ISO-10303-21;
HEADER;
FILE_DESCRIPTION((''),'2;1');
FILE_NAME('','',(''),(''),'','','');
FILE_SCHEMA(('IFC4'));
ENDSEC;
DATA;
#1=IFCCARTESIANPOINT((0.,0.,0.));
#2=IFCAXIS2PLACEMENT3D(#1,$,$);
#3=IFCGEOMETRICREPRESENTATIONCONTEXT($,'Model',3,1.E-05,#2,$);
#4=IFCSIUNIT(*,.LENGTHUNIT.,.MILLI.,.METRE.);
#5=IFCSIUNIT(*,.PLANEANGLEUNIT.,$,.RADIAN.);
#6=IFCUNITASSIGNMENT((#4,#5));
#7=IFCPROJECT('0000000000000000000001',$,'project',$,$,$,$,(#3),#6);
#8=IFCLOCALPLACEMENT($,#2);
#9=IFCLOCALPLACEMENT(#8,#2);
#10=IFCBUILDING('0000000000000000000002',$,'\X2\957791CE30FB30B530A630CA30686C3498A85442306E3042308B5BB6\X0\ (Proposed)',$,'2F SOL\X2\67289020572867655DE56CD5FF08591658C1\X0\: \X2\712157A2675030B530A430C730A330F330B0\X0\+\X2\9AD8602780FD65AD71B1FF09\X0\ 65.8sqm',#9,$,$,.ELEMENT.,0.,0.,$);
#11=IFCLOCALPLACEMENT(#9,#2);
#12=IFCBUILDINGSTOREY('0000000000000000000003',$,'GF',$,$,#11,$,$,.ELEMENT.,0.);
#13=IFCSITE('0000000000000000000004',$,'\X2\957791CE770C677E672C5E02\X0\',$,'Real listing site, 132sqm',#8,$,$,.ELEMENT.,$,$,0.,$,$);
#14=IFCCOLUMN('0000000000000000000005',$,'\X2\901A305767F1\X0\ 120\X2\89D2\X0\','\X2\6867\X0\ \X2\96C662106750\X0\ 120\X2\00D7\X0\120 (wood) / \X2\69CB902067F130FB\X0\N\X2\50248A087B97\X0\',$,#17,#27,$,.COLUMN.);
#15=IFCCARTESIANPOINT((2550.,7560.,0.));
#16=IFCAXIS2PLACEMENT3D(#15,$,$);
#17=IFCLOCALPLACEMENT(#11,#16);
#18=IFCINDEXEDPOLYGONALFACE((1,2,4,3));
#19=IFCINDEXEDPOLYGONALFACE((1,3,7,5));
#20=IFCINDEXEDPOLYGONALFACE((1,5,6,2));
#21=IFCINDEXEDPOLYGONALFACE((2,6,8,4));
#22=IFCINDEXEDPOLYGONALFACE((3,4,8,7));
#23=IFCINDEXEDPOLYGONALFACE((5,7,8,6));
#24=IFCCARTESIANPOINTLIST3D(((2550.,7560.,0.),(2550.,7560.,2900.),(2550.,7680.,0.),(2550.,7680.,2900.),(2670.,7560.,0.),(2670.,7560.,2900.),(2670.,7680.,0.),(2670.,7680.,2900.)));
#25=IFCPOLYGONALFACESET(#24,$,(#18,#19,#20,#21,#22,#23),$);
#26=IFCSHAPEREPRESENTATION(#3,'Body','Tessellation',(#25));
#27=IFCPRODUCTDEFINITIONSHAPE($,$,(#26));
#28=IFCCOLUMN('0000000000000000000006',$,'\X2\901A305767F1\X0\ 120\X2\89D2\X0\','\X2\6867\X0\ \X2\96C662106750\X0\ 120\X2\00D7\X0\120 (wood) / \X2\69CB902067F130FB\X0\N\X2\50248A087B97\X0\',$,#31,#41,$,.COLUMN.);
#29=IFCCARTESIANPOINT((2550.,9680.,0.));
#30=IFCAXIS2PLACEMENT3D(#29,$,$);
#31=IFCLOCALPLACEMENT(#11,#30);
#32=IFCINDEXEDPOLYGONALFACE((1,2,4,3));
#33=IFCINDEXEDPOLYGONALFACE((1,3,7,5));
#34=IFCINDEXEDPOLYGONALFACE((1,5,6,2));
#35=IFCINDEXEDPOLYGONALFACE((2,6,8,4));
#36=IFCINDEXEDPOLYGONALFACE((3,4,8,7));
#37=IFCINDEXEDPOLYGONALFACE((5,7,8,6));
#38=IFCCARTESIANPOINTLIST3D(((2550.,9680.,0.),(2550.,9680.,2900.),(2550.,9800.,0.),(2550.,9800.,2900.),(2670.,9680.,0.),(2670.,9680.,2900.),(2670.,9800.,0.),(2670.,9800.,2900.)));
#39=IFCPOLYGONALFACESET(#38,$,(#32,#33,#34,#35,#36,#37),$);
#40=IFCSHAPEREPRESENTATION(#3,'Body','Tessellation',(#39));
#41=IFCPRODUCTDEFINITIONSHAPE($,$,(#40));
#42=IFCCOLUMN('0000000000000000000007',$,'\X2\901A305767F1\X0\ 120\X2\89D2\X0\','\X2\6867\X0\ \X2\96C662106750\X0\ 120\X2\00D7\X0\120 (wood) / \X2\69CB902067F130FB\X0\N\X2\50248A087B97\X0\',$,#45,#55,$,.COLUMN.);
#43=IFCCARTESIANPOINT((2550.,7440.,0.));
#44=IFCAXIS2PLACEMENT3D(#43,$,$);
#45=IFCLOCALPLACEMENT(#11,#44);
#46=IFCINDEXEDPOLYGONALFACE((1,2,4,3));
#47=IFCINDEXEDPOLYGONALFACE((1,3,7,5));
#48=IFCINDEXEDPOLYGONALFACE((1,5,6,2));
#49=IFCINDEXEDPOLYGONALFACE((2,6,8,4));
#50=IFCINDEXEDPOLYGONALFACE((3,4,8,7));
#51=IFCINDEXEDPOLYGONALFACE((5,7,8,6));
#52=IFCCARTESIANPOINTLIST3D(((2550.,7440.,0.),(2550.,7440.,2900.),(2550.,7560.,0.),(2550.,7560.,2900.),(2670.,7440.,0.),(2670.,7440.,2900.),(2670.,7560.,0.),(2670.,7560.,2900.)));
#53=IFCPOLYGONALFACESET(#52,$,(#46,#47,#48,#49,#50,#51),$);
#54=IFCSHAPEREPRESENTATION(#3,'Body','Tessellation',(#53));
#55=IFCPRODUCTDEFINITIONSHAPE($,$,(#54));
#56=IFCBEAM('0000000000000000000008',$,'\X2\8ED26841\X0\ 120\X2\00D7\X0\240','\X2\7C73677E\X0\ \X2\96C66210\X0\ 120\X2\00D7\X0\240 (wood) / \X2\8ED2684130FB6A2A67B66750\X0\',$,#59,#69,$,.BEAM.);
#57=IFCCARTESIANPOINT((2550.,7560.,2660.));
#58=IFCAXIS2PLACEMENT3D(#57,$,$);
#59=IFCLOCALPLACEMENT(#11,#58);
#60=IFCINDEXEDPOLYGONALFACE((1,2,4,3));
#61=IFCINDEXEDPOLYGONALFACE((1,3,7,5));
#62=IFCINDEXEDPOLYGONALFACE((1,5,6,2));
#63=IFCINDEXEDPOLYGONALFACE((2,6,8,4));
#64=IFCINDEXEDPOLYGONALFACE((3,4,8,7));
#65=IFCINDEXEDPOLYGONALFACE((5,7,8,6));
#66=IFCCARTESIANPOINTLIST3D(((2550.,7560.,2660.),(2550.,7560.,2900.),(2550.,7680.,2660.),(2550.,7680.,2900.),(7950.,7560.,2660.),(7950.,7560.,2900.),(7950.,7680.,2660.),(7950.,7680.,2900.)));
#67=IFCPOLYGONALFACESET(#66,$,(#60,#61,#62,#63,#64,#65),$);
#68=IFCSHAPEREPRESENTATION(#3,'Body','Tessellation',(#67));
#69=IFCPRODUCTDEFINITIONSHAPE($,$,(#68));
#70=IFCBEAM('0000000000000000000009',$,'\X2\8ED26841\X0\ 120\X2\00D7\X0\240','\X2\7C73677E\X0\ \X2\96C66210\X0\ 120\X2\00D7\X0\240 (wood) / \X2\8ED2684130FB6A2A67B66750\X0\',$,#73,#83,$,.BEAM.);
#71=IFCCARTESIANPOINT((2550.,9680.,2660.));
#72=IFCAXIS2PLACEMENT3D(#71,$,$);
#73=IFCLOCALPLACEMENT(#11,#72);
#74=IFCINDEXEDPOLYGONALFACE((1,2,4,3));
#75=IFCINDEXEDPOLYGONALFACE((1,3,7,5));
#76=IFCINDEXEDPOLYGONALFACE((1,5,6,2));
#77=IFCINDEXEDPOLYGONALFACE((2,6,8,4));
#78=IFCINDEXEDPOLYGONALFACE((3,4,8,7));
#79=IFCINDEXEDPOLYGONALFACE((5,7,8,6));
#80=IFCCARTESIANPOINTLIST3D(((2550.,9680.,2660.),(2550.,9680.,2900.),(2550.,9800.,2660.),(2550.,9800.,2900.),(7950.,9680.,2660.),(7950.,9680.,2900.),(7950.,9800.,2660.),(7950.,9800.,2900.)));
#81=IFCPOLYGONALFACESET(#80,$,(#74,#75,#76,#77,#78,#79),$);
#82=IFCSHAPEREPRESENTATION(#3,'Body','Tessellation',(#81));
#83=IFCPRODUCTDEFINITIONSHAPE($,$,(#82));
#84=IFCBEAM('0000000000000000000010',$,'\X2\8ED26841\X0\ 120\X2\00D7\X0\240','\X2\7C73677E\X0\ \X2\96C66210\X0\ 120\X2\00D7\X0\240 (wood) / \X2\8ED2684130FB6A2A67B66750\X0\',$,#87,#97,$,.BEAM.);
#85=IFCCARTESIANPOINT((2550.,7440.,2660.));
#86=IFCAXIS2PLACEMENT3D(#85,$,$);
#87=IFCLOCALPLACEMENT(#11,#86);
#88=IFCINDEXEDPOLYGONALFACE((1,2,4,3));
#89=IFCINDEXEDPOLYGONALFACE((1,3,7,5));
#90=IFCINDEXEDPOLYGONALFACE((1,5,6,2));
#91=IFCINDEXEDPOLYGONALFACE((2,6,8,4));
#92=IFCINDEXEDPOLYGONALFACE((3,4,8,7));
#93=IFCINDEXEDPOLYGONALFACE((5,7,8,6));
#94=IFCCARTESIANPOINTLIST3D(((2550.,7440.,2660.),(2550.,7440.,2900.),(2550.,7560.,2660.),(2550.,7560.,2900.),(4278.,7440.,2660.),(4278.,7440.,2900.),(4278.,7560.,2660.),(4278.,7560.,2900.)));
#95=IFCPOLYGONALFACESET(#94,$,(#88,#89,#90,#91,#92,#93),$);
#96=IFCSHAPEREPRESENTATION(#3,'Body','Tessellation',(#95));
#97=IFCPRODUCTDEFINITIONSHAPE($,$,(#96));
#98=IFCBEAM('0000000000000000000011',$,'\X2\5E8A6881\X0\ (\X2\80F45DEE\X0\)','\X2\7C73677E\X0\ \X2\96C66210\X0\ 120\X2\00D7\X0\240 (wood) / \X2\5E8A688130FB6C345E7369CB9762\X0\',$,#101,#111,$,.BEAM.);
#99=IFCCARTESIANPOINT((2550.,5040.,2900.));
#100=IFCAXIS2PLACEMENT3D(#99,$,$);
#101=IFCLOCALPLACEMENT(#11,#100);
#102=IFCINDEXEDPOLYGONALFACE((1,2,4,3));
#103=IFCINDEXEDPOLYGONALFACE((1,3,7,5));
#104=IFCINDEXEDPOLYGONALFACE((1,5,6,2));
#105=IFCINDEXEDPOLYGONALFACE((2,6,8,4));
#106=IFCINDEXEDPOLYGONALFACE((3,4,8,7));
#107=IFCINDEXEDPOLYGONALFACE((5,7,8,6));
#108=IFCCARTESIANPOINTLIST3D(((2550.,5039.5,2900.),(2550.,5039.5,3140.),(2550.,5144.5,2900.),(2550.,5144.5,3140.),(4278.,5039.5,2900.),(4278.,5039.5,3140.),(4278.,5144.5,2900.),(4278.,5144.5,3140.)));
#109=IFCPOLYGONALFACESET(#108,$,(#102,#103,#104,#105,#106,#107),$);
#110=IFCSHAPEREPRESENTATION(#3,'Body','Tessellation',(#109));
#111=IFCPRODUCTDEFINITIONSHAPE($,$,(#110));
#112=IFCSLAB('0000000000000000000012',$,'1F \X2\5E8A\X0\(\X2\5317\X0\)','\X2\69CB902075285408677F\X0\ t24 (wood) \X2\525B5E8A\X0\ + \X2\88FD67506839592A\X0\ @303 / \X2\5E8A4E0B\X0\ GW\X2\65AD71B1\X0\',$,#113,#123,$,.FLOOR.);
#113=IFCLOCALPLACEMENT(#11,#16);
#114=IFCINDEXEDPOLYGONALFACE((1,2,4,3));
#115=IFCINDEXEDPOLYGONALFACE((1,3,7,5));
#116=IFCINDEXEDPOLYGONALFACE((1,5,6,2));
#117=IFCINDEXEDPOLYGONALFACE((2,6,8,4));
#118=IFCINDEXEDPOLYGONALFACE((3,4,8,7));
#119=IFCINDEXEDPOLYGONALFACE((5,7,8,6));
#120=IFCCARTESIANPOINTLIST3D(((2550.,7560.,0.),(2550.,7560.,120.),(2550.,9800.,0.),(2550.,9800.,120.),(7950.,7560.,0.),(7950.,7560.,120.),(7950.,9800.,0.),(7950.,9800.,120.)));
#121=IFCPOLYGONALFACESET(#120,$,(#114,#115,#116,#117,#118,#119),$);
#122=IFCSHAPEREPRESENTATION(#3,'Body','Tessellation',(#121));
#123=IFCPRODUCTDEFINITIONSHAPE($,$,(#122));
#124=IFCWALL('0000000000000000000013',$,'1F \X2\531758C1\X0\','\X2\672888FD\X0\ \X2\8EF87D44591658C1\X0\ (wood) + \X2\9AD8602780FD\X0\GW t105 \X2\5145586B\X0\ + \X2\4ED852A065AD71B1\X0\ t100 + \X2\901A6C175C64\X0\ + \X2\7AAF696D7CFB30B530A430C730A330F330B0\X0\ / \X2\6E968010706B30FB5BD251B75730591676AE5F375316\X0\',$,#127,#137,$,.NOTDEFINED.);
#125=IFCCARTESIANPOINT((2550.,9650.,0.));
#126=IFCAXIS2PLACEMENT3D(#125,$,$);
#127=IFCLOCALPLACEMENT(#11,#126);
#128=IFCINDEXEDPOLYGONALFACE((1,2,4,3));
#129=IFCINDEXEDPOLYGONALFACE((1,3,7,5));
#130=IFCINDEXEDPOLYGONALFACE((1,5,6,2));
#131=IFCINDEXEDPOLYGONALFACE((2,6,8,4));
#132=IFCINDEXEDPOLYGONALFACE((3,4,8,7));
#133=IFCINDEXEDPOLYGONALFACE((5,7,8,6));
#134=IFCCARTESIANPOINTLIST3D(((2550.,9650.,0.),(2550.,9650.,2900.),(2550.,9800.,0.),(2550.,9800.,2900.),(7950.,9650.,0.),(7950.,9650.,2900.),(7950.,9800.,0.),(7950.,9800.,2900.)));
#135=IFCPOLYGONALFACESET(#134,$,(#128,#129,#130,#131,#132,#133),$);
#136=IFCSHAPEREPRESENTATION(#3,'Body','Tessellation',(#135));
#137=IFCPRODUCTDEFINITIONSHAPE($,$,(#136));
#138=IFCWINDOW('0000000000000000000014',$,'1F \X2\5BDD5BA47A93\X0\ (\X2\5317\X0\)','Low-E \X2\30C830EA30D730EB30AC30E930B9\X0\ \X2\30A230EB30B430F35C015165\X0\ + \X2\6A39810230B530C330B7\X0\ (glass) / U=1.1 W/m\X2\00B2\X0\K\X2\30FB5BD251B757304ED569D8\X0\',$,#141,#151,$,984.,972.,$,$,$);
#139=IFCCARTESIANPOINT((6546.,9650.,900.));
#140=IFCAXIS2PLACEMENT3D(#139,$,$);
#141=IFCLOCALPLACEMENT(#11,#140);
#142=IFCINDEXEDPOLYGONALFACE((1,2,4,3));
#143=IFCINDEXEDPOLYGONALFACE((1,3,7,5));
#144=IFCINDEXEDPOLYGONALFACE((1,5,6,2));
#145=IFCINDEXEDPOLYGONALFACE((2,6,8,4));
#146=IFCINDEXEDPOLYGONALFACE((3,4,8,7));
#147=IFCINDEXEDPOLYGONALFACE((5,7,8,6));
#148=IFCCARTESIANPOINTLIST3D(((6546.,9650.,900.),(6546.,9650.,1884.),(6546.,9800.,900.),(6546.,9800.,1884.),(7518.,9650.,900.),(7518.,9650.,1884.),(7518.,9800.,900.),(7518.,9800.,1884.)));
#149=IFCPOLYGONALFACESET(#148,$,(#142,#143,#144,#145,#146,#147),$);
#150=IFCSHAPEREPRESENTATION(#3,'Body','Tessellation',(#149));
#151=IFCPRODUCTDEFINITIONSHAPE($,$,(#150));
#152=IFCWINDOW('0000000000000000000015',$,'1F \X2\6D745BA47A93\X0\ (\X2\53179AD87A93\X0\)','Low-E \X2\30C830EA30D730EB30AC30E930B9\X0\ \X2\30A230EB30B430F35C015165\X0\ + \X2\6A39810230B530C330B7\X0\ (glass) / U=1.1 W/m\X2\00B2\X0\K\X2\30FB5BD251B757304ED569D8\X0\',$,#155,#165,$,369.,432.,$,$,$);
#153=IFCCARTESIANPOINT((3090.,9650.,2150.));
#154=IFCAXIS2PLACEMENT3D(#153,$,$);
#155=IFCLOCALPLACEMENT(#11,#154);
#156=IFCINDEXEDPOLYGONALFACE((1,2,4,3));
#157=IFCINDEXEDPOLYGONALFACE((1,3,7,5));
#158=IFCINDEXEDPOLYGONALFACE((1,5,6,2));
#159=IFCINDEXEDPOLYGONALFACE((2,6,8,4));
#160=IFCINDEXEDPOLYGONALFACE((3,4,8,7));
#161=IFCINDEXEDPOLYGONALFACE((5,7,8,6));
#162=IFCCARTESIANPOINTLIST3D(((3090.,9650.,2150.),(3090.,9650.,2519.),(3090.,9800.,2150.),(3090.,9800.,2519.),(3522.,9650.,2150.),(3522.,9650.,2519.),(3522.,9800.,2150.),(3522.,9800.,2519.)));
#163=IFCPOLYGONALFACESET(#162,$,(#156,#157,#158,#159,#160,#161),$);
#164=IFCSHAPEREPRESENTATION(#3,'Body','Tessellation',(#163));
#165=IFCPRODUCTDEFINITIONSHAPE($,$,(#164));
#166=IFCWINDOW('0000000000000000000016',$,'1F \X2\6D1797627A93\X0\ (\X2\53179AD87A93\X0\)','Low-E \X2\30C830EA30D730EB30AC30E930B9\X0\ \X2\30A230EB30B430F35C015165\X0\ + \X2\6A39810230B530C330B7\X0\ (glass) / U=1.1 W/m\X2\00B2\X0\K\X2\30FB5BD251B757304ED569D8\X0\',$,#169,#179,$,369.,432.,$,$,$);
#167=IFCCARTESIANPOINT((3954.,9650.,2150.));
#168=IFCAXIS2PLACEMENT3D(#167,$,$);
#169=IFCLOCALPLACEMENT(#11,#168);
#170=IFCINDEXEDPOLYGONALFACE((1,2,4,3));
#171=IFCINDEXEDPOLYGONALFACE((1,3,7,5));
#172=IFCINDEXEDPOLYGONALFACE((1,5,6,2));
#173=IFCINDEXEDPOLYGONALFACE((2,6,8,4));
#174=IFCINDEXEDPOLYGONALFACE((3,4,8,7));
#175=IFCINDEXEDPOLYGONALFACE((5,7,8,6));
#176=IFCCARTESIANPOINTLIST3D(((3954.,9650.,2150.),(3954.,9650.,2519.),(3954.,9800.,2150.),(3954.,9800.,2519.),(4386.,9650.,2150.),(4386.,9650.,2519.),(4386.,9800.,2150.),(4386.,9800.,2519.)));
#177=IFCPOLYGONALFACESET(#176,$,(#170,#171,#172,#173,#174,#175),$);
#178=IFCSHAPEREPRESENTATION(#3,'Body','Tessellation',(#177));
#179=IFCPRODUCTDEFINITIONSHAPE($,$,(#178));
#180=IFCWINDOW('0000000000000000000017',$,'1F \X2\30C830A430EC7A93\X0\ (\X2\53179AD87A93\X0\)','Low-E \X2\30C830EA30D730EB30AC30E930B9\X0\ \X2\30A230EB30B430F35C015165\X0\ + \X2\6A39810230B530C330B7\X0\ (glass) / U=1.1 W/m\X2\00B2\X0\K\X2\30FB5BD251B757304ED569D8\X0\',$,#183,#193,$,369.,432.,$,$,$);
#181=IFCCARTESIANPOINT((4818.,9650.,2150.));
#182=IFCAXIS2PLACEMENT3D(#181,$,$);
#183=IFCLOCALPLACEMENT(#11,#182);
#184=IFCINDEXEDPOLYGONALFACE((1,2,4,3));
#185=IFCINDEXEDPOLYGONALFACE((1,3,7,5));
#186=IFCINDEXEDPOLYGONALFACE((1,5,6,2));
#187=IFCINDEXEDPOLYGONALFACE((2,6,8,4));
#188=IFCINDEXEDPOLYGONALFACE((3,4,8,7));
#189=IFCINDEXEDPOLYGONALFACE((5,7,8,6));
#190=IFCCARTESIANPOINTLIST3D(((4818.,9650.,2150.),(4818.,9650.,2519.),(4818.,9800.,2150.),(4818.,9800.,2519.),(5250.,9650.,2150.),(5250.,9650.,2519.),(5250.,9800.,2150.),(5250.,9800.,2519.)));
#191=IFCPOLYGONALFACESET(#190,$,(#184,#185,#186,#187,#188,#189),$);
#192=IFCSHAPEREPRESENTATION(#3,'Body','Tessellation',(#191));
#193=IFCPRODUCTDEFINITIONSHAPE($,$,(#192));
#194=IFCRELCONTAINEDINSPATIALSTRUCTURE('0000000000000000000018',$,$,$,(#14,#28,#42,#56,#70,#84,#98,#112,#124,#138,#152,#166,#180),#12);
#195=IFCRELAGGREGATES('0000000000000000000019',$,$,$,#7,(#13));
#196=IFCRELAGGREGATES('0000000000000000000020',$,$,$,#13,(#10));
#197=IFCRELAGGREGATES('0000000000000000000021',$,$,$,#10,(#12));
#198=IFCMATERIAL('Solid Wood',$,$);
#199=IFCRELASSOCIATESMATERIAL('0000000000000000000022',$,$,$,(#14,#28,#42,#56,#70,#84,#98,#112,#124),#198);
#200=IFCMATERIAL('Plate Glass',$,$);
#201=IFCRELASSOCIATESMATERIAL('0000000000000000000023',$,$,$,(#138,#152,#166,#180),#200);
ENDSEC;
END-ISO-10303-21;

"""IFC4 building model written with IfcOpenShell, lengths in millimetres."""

from ifc_helpers import new_model, si_unit, frame, frame_2d, origin, place, context, project, spatial, rectangle, extrude, material, element, fill, save


model = new_model("IFC4")

# Units and contexts
model_context = context("Model", 3, precision=1e-05, world=origin())
ifc_project = project(units=[si_unit("LENGTHUNIT", "METRE", prefix="MILLI"), si_unit("PLANEANGLEUNIT", "RADIAN")], contexts=[model_context])

# Site, building, storey
site_placement = place(None, origin())
site = spatial("IfcSite", under=ifc_project, at=site_placement, Name="長野県松本市", ObjectType="Real listing site, 132sqm", CompositionType="ELEMENT", RefElevation=0.0)
building_placement = place(site_placement, origin())
building = spatial("IfcBuilding", under=site, at=building_placement, Name="長野・サウナと水風呂のある家 (Proposed)", ObjectType="2F SOL木造在来工法（外壁: 無垢材サイディング+高性能断熱） 65.8sqm", CompositionType="ELEMENT", ElevationOfRefHeight=0.0, ElevationOfTerrain=0.0)
storey_placement = place(building_placement, origin())
storey = spatial("IfcBuildingStorey", under=building, at=storey_placement, Name="GF", CompositionType="ELEMENT", Elevation=0.0)

# Columns
ifc_material_1 = material(Name="Solid Wood")
column_1_placement = place(storey_placement, frame((2550.0, 7560.0, 0.0)))
element("IfcColumn", 1, at=column_1_placement, inside=storey, material=ifc_material_1, Name="通し柱 120角", Description="桧 集成材 120×120 (wood) / 構造柱・N値計算", PredefinedType="COLUMN", context=model_context, shape_type="SweptSolid", body=[
    extrude(rectangle(XDim=120.0, YDim=120.0, at=frame_2d((60.0, 60.0))), frame((2550.0, 7560.0, 0.0)), (0.0, 0.0, 1.0), 2900.0),
])
column_2_placement = place(storey_placement, frame((2550.0, 9680.0, 0.0)))
element("IfcColumn", 2, at=column_2_placement, inside=storey, material=ifc_material_1, Name="通し柱 120角", Description="桧 集成材 120×120 (wood) / 構造柱・N値計算", PredefinedType="COLUMN", context=model_context, shape_type="SweptSolid", body=[
    extrude(rectangle(XDim=120.0, YDim=120.0, at=frame_2d((60.0, 60.0))), frame((2550.0, 9680.0, 0.0)), (0.0, 0.0, 1.0), 2900.0),
])
column_3_placement = place(storey_placement, frame((2550.0, 7440.0, 0.0)))
element("IfcColumn", 3, at=column_3_placement, inside=storey, material=ifc_material_1, Name="通し柱 120角", Description="桧 集成材 120×120 (wood) / 構造柱・N値計算", PredefinedType="COLUMN", context=model_context, shape_type="SweptSolid", body=[
    extrude(rectangle(XDim=120.0, YDim=120.0, at=frame_2d((60.0, 60.0))), frame((2550.0, 7440.0, 0.0)), (0.0, 0.0, 1.0), 2900.0),
])

# Beams
beam_1_placement = place(storey_placement, frame((2550.0, 7560.0, 2660.0)))
element("IfcBeam", 4, at=beam_1_placement, inside=storey, material=ifc_material_1, Name="軒桁 120×240", Description="米松 集成 120×240 (wood) / 軒桁・横架材", PredefinedType="BEAM", context=model_context, shape_type="SweptSolid", body=[
    extrude(rectangle(XDim=5400.0, YDim=120.0, at=frame_2d((2700.0, 60.0))), frame((2550.0, 7560.0, 2660.0)), (0.0, 0.0, 1.0), 240.0),
])
beam_2_placement = place(storey_placement, frame((2550.0, 9680.0, 2660.0)))
element("IfcBeam", 5, at=beam_2_placement, inside=storey, material=ifc_material_1, Name="軒桁 120×240", Description="米松 集成 120×240 (wood) / 軒桁・横架材", PredefinedType="BEAM", context=model_context, shape_type="SweptSolid", body=[
    extrude(rectangle(XDim=5400.0, YDim=120.0, at=frame_2d((2700.0, 60.0))), frame((2550.0, 9680.0, 2660.0)), (0.0, 0.0, 1.0), 240.0),
])
beam_3_placement = place(storey_placement, frame((2550.0, 7440.0, 2660.0)))
element("IfcBeam", 6, at=beam_3_placement, inside=storey, material=ifc_material_1, Name="軒桁 120×240", Description="米松 集成 120×240 (wood) / 軒桁・横架材", PredefinedType="BEAM", context=model_context, shape_type="SweptSolid", body=[
    extrude(rectangle(XDim=1728.0, YDim=120.0, at=frame_2d((864.0, 60.0))), frame((2550.0, 7440.0, 2660.0)), (0.0, 0.0, 1.0), 240.0),
])
beam_4_placement = place(storey_placement, frame((2550.0, 5040.0, 2900.0)))
element("IfcBeam", 7, at=beam_4_placement, inside=storey, material=ifc_material_1, Name="床梁 (胴差)", Description="米松 集成 120×240 (wood) / 床梁・水平構面", PredefinedType="BEAM", context=model_context, shape_type="SweptSolid", body=[
    extrude(rectangle(XDim=1728.0, YDim=105.0, at=frame_2d((864.0, 52.0))), frame((2550.0, 5040.0, 2900.0)), (0.0, 0.0, 1.0), 240.0),
])

# Slab
slab_placement = place(storey_placement, frame((2550.0, 7560.0, 0.0)))
element("IfcSlab", 8, at=slab_placement, inside=storey, material=ifc_material_1, Name="1F 床(北)", Description="構造用合板 t24 (wood) 剛床 + 製材根太 @303 / 床下 GW断熱", PredefinedType="FLOOR", context=model_context, shape_type="SweptSolid", body=[
    extrude(rectangle(XDim=5400.0, YDim=2240.0, at=frame_2d((2700.0, 1120.0))), frame((2550.0, 7560.0, 0.0)), (0.0, 0.0, 1.0), 120.0),
])

# Wall, openings, windows
wall_1_placement = place(storey_placement, frame((2550.0, 9650.0, 0.0)))
wall_1 = element("IfcWall", 9, at=wall_1_placement, inside=storey, material=ifc_material_1, Name="1F 北壁", Description="木製 軸組外壁 (wood) + 高性能GW t105 充填 + 付加断熱 t100 + 通気層 + 窯業系サイディング / 準耐火・寒冷地外皮強化", PredefinedType="NOTDEFINED", context=model_context, shape_type="SweptSolid", body=[
    extrude(rectangle(XDim=5400.0, YDim=150.0, at=frame_2d((2700.0, 75.0))), frame((2550.0, 9650.0, 0.0)), (0.0, 0.0, 1.0), 2900.0),
])
opening_1_placement = place(storey_placement, frame((6546.0, 9650.0, 900.0)))
opening_1 = element("IfcOpeningElement", 10, at=opening_1_placement, cuts=wall_1, PredefinedType="NOTDEFINED", context=model_context, shape_type="SweptSolid", body=[
    extrude(rectangle(XDim=972.0, YDim=150.0, at=frame_2d((486.0, 75.0))), frame((6546.0, 9650.0, 900.0)), (0.0, 0.0, 1.0), 984.0),
])
opening_2_placement = place(storey_placement, frame((3090.0, 9650.0, 2150.0)))
opening_2 = element("IfcOpeningElement", 11, at=opening_2_placement, cuts=wall_1, PredefinedType="NOTDEFINED", context=model_context, shape_type="SweptSolid", body=[
    extrude(rectangle(XDim=432.0, YDim=150.0, at=frame_2d((216.0, 75.0))), frame((3090.0, 9650.0, 2150.0)), (0.0, 0.0, 1.0), 369.0),
])
opening_3_placement = place(storey_placement, frame((3954.0, 9650.0, 2150.0)))
opening_3 = element("IfcOpeningElement", 12, at=opening_3_placement, cuts=wall_1, PredefinedType="NOTDEFINED", context=model_context, shape_type="SweptSolid", body=[
    extrude(rectangle(XDim=432.0, YDim=150.0, at=frame_2d((216.0, 75.0))), frame((3954.0, 9650.0, 2150.0)), (0.0, 0.0, 1.0), 369.0),
])
opening_4_placement = place(storey_placement, frame((4818.0, 9650.0, 2150.0)))
opening_4 = element("IfcOpeningElement", 13, at=opening_4_placement, cuts=wall_1, PredefinedType="NOTDEFINED", context=model_context, shape_type="SweptSolid", body=[
    extrude(rectangle(XDim=432.0, YDim=150.0, at=frame_2d((216.0, 75.0))), frame((4818.0, 9650.0, 2150.0)), (0.0, 0.0, 1.0), 369.0),
])
ifc_material_2 = material(Name="Plate Glass")
window_1_placement = place(storey_placement, frame((6546.0, 9650.0, 900.0)))
window_1 = element("IfcWindow", 14, at=window_1_placement, inside=storey, material=ifc_material_2, Name="1F 寝室窓 (北)", Description="Low-E トリプルガラス アルゴン封入 + 樹脂サッシ (glass) / U=1.1 W/m²K・寒冷地仕様", OverallHeight=984.0, OverallWidth=972.0, context=model_context, shape_type="SweptSolid", body=[
    extrude(rectangle(XDim=972.0, YDim=150.0, at=frame_2d((486.0, 75.0))), frame((6546.0, 9650.0, 900.0)), (0.0, 0.0, 1.0), 984.0),
])
fill(opening_1, window_1)
window_2_placement = place(storey_placement, frame((3090.0, 9650.0, 2150.0)))
window_2 = element("IfcWindow", 15, at=window_2_placement, inside=storey, material=ifc_material_2, Name="1F 浴室窓 (北高窓)", Description="Low-E トリプルガラス アルゴン封入 + 樹脂サッシ (glass) / U=1.1 W/m²K・寒冷地仕様", OverallHeight=369.0, OverallWidth=432.0, context=model_context, shape_type="SweptSolid", body=[
    extrude(rectangle(XDim=432.0, YDim=150.0, at=frame_2d((216.0, 75.0))), frame((3090.0, 9650.0, 2150.0)), (0.0, 0.0, 1.0), 369.0),
])
fill(opening_2, window_2)
window_3_placement = place(storey_placement, frame((3954.0, 9650.0, 2150.0)))
window_3 = element("IfcWindow", 16, at=window_3_placement, inside=storey, material=ifc_material_2, Name="1F 洗面窓 (北高窓)", Description="Low-E トリプルガラス アルゴン封入 + 樹脂サッシ (glass) / U=1.1 W/m²K・寒冷地仕様", OverallHeight=369.0, OverallWidth=432.0, context=model_context, shape_type="SweptSolid", body=[
    extrude(rectangle(XDim=432.0, YDim=150.0, at=frame_2d((216.0, 75.0))), frame((3954.0, 9650.0, 2150.0)), (0.0, 0.0, 1.0), 369.0),
])
fill(opening_3, window_3)
window_4_placement = place(storey_placement, frame((4818.0, 9650.0, 2150.0)))
window_4 = element("IfcWindow", 17, at=window_4_placement, inside=storey, material=ifc_material_2, Name="1F トイレ窓 (北高窓)", Description="Low-E トリプルガラス アルゴン封入 + 樹脂サッシ (glass) / U=1.1 W/m²K・寒冷地仕様", OverallHeight=369.0, OverallWidth=432.0, context=model_context, shape_type="SweptSolid", body=[
    extrude(rectangle(XDim=432.0, YDim=150.0, at=frame_2d((216.0, 75.0))), frame((4818.0, 9650.0, 2150.0)), (0.0, 0.0, 1.0), 369.0),
])
fill(opening_4, window_4)

save(model, "model.ifc")
